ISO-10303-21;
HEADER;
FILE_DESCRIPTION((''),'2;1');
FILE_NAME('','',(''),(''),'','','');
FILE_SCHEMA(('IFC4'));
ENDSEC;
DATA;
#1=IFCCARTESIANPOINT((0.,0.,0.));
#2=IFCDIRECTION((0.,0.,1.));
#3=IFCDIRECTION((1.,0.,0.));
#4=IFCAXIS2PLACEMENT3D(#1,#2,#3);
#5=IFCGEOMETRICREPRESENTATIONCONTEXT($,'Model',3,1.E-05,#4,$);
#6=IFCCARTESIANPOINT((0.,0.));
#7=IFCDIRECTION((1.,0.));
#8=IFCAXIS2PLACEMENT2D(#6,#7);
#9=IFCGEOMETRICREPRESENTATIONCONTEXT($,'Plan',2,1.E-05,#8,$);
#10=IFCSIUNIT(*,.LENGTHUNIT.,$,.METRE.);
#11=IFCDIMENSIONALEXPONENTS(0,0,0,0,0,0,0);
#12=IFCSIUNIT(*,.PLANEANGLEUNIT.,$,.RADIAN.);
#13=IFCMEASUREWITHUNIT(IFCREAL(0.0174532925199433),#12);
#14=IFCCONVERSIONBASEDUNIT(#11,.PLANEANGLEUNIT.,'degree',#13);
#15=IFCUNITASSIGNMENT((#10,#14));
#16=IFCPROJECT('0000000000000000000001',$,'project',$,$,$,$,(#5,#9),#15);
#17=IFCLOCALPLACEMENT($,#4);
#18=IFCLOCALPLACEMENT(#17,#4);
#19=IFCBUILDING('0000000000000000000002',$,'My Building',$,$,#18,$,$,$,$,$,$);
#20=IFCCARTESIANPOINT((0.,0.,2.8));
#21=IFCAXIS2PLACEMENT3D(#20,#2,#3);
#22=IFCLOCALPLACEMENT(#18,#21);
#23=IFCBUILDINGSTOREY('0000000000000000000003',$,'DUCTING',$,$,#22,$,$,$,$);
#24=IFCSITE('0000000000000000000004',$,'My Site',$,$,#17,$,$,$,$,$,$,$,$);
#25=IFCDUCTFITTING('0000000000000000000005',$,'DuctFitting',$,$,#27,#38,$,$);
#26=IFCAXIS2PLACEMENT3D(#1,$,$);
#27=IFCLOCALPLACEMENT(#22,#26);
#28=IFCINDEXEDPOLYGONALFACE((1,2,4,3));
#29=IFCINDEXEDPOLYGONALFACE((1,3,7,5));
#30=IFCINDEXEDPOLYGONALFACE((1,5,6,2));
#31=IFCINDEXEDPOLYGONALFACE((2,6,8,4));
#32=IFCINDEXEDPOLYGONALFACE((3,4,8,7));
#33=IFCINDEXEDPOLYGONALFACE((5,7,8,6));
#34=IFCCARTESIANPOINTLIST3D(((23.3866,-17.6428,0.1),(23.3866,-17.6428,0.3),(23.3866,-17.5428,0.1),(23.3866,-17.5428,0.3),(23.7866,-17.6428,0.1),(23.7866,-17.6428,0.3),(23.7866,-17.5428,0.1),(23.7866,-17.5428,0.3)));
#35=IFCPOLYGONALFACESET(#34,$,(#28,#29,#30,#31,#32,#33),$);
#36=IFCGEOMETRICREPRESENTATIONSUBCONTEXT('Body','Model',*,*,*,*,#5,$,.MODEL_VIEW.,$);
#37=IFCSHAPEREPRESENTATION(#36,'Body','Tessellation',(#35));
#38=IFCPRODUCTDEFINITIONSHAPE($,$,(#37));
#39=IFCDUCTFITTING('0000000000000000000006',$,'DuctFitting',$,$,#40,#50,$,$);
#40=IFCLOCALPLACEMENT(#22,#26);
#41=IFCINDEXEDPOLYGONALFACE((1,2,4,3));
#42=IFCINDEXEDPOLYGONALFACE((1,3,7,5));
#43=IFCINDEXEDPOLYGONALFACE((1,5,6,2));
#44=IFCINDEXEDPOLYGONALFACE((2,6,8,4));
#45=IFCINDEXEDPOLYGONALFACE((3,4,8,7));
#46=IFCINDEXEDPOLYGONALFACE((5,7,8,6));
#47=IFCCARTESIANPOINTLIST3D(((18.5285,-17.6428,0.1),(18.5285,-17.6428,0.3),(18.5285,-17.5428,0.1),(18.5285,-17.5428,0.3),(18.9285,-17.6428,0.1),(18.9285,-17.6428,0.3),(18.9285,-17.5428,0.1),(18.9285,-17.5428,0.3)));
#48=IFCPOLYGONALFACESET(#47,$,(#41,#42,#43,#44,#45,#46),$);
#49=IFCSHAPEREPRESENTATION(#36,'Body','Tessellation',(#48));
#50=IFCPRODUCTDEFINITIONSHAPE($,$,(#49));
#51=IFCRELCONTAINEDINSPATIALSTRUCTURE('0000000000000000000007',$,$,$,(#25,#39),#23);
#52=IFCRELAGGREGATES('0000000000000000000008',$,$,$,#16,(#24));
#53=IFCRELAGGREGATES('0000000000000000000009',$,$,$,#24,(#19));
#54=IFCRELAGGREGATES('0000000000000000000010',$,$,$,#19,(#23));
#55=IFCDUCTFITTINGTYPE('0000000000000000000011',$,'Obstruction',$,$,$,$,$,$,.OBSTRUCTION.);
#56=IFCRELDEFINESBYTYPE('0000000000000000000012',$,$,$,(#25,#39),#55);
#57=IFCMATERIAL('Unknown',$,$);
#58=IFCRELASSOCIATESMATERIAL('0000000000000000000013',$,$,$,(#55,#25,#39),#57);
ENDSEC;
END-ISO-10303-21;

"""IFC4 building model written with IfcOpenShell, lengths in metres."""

from ifc_helpers import new_model, entity, si_unit, converted_unit, frame, origin_with_axes, origin_2d_with_axis, place, context, subcontext, project, spatial, rectangle, extrude, material, material_profile, profile_set, profile_usage, type_object, element, save


model = new_model("IFC4")

# Units and contexts
model_context = context("Model", 3, precision=1e-05, world=origin_with_axes())
plan_context = context("Plan", 2, precision=1e-05, world=origin_2d_with_axis())
body_context = subcontext(model_context, "Body", "Model", "MODEL_VIEW")
ifc_project = project(units=[si_unit("LENGTHUNIT", "METRE"), converted_unit("PLANEANGLEUNIT", "degree", entity("IfcReal", 0.0174532925199433), si_unit("PLANEANGLEUNIT", "RADIAN"), dimensions=[0, 0, 0, 0, 0, 0, 0])], contexts=[model_context, plan_context])

# Site, building, storey
site_placement = place(None, origin_with_axes())
site = spatial("IfcSite", under=ifc_project, at=site_placement, Name="My Site")
building_placement = place(site_placement, origin_with_axes())
building = spatial("IfcBuilding", under=site, at=building_placement, Name="My Building")
storey_placement = place(building_placement, frame((0.0, 0.0, 2.8), z_axis=(0.0, 0.0, 1.0), x_axis=(1.0, 0.0, 0.0)))
storey = spatial("IfcBuildingStorey", under=building, at=storey_placement, Name="DUCTING")

# Shared definitions
ifc_material = material(Name="Unknown")

# Duct fittings
ifc_material_profile_1 = material_profile(ifc_material, rectangle(XDim=0.4, YDim=0.2))
ifc_profile_set_1 = profile_set([ifc_material_profile_1])
duct_fitting_type_1 = type_object("IfcDuctFittingType", Name="Obstruction", PredefinedType="OBSTRUCTION", material=ifc_profile_set_1)
ifc_profile_usage_1 = profile_usage(ifc_profile_set_1, cardinal=5)
duct_fitting_1_placement = place(storey_placement, frame((23.5866, -17.6428, 0.2), z_axis=(0.0, 1.0, 0.0), x_axis=(-1.0, 0.0, 0.0)))
element("IfcDuctFitting", 1, at=duct_fitting_1_placement, inside=storey, type_object=duct_fitting_type_1, material=ifc_profile_usage_1, Name="DuctFitting", context=body_context, shape_type="SweptSolid", body=[
    extrude(rectangle(XDim=0.4, YDim=0.2), origin_with_axes(), (0.0, 0.0, 1.0), 0.1),
])
ifc_profile_usage_2 = profile_usage(ifc_profile_set_1, cardinal=5)
duct_fitting_2_placement = place(storey_placement, frame((18.7285, -17.6428, 0.2), z_axis=(0.0, 1.0, 0.0), x_axis=(-1.0, 0.0, 0.0)))
element("IfcDuctFitting", 2, at=duct_fitting_2_placement, inside=storey, type_object=duct_fitting_type_1, material=ifc_profile_usage_2, Name="DuctFitting", context=body_context, shape_type="SweptSolid", body=[
    extrude(rectangle(XDim=0.4, YDim=0.2), origin_with_axes(), (0.0, 0.0, 1.0), 0.1),
])

save(model, "model.ifc")
